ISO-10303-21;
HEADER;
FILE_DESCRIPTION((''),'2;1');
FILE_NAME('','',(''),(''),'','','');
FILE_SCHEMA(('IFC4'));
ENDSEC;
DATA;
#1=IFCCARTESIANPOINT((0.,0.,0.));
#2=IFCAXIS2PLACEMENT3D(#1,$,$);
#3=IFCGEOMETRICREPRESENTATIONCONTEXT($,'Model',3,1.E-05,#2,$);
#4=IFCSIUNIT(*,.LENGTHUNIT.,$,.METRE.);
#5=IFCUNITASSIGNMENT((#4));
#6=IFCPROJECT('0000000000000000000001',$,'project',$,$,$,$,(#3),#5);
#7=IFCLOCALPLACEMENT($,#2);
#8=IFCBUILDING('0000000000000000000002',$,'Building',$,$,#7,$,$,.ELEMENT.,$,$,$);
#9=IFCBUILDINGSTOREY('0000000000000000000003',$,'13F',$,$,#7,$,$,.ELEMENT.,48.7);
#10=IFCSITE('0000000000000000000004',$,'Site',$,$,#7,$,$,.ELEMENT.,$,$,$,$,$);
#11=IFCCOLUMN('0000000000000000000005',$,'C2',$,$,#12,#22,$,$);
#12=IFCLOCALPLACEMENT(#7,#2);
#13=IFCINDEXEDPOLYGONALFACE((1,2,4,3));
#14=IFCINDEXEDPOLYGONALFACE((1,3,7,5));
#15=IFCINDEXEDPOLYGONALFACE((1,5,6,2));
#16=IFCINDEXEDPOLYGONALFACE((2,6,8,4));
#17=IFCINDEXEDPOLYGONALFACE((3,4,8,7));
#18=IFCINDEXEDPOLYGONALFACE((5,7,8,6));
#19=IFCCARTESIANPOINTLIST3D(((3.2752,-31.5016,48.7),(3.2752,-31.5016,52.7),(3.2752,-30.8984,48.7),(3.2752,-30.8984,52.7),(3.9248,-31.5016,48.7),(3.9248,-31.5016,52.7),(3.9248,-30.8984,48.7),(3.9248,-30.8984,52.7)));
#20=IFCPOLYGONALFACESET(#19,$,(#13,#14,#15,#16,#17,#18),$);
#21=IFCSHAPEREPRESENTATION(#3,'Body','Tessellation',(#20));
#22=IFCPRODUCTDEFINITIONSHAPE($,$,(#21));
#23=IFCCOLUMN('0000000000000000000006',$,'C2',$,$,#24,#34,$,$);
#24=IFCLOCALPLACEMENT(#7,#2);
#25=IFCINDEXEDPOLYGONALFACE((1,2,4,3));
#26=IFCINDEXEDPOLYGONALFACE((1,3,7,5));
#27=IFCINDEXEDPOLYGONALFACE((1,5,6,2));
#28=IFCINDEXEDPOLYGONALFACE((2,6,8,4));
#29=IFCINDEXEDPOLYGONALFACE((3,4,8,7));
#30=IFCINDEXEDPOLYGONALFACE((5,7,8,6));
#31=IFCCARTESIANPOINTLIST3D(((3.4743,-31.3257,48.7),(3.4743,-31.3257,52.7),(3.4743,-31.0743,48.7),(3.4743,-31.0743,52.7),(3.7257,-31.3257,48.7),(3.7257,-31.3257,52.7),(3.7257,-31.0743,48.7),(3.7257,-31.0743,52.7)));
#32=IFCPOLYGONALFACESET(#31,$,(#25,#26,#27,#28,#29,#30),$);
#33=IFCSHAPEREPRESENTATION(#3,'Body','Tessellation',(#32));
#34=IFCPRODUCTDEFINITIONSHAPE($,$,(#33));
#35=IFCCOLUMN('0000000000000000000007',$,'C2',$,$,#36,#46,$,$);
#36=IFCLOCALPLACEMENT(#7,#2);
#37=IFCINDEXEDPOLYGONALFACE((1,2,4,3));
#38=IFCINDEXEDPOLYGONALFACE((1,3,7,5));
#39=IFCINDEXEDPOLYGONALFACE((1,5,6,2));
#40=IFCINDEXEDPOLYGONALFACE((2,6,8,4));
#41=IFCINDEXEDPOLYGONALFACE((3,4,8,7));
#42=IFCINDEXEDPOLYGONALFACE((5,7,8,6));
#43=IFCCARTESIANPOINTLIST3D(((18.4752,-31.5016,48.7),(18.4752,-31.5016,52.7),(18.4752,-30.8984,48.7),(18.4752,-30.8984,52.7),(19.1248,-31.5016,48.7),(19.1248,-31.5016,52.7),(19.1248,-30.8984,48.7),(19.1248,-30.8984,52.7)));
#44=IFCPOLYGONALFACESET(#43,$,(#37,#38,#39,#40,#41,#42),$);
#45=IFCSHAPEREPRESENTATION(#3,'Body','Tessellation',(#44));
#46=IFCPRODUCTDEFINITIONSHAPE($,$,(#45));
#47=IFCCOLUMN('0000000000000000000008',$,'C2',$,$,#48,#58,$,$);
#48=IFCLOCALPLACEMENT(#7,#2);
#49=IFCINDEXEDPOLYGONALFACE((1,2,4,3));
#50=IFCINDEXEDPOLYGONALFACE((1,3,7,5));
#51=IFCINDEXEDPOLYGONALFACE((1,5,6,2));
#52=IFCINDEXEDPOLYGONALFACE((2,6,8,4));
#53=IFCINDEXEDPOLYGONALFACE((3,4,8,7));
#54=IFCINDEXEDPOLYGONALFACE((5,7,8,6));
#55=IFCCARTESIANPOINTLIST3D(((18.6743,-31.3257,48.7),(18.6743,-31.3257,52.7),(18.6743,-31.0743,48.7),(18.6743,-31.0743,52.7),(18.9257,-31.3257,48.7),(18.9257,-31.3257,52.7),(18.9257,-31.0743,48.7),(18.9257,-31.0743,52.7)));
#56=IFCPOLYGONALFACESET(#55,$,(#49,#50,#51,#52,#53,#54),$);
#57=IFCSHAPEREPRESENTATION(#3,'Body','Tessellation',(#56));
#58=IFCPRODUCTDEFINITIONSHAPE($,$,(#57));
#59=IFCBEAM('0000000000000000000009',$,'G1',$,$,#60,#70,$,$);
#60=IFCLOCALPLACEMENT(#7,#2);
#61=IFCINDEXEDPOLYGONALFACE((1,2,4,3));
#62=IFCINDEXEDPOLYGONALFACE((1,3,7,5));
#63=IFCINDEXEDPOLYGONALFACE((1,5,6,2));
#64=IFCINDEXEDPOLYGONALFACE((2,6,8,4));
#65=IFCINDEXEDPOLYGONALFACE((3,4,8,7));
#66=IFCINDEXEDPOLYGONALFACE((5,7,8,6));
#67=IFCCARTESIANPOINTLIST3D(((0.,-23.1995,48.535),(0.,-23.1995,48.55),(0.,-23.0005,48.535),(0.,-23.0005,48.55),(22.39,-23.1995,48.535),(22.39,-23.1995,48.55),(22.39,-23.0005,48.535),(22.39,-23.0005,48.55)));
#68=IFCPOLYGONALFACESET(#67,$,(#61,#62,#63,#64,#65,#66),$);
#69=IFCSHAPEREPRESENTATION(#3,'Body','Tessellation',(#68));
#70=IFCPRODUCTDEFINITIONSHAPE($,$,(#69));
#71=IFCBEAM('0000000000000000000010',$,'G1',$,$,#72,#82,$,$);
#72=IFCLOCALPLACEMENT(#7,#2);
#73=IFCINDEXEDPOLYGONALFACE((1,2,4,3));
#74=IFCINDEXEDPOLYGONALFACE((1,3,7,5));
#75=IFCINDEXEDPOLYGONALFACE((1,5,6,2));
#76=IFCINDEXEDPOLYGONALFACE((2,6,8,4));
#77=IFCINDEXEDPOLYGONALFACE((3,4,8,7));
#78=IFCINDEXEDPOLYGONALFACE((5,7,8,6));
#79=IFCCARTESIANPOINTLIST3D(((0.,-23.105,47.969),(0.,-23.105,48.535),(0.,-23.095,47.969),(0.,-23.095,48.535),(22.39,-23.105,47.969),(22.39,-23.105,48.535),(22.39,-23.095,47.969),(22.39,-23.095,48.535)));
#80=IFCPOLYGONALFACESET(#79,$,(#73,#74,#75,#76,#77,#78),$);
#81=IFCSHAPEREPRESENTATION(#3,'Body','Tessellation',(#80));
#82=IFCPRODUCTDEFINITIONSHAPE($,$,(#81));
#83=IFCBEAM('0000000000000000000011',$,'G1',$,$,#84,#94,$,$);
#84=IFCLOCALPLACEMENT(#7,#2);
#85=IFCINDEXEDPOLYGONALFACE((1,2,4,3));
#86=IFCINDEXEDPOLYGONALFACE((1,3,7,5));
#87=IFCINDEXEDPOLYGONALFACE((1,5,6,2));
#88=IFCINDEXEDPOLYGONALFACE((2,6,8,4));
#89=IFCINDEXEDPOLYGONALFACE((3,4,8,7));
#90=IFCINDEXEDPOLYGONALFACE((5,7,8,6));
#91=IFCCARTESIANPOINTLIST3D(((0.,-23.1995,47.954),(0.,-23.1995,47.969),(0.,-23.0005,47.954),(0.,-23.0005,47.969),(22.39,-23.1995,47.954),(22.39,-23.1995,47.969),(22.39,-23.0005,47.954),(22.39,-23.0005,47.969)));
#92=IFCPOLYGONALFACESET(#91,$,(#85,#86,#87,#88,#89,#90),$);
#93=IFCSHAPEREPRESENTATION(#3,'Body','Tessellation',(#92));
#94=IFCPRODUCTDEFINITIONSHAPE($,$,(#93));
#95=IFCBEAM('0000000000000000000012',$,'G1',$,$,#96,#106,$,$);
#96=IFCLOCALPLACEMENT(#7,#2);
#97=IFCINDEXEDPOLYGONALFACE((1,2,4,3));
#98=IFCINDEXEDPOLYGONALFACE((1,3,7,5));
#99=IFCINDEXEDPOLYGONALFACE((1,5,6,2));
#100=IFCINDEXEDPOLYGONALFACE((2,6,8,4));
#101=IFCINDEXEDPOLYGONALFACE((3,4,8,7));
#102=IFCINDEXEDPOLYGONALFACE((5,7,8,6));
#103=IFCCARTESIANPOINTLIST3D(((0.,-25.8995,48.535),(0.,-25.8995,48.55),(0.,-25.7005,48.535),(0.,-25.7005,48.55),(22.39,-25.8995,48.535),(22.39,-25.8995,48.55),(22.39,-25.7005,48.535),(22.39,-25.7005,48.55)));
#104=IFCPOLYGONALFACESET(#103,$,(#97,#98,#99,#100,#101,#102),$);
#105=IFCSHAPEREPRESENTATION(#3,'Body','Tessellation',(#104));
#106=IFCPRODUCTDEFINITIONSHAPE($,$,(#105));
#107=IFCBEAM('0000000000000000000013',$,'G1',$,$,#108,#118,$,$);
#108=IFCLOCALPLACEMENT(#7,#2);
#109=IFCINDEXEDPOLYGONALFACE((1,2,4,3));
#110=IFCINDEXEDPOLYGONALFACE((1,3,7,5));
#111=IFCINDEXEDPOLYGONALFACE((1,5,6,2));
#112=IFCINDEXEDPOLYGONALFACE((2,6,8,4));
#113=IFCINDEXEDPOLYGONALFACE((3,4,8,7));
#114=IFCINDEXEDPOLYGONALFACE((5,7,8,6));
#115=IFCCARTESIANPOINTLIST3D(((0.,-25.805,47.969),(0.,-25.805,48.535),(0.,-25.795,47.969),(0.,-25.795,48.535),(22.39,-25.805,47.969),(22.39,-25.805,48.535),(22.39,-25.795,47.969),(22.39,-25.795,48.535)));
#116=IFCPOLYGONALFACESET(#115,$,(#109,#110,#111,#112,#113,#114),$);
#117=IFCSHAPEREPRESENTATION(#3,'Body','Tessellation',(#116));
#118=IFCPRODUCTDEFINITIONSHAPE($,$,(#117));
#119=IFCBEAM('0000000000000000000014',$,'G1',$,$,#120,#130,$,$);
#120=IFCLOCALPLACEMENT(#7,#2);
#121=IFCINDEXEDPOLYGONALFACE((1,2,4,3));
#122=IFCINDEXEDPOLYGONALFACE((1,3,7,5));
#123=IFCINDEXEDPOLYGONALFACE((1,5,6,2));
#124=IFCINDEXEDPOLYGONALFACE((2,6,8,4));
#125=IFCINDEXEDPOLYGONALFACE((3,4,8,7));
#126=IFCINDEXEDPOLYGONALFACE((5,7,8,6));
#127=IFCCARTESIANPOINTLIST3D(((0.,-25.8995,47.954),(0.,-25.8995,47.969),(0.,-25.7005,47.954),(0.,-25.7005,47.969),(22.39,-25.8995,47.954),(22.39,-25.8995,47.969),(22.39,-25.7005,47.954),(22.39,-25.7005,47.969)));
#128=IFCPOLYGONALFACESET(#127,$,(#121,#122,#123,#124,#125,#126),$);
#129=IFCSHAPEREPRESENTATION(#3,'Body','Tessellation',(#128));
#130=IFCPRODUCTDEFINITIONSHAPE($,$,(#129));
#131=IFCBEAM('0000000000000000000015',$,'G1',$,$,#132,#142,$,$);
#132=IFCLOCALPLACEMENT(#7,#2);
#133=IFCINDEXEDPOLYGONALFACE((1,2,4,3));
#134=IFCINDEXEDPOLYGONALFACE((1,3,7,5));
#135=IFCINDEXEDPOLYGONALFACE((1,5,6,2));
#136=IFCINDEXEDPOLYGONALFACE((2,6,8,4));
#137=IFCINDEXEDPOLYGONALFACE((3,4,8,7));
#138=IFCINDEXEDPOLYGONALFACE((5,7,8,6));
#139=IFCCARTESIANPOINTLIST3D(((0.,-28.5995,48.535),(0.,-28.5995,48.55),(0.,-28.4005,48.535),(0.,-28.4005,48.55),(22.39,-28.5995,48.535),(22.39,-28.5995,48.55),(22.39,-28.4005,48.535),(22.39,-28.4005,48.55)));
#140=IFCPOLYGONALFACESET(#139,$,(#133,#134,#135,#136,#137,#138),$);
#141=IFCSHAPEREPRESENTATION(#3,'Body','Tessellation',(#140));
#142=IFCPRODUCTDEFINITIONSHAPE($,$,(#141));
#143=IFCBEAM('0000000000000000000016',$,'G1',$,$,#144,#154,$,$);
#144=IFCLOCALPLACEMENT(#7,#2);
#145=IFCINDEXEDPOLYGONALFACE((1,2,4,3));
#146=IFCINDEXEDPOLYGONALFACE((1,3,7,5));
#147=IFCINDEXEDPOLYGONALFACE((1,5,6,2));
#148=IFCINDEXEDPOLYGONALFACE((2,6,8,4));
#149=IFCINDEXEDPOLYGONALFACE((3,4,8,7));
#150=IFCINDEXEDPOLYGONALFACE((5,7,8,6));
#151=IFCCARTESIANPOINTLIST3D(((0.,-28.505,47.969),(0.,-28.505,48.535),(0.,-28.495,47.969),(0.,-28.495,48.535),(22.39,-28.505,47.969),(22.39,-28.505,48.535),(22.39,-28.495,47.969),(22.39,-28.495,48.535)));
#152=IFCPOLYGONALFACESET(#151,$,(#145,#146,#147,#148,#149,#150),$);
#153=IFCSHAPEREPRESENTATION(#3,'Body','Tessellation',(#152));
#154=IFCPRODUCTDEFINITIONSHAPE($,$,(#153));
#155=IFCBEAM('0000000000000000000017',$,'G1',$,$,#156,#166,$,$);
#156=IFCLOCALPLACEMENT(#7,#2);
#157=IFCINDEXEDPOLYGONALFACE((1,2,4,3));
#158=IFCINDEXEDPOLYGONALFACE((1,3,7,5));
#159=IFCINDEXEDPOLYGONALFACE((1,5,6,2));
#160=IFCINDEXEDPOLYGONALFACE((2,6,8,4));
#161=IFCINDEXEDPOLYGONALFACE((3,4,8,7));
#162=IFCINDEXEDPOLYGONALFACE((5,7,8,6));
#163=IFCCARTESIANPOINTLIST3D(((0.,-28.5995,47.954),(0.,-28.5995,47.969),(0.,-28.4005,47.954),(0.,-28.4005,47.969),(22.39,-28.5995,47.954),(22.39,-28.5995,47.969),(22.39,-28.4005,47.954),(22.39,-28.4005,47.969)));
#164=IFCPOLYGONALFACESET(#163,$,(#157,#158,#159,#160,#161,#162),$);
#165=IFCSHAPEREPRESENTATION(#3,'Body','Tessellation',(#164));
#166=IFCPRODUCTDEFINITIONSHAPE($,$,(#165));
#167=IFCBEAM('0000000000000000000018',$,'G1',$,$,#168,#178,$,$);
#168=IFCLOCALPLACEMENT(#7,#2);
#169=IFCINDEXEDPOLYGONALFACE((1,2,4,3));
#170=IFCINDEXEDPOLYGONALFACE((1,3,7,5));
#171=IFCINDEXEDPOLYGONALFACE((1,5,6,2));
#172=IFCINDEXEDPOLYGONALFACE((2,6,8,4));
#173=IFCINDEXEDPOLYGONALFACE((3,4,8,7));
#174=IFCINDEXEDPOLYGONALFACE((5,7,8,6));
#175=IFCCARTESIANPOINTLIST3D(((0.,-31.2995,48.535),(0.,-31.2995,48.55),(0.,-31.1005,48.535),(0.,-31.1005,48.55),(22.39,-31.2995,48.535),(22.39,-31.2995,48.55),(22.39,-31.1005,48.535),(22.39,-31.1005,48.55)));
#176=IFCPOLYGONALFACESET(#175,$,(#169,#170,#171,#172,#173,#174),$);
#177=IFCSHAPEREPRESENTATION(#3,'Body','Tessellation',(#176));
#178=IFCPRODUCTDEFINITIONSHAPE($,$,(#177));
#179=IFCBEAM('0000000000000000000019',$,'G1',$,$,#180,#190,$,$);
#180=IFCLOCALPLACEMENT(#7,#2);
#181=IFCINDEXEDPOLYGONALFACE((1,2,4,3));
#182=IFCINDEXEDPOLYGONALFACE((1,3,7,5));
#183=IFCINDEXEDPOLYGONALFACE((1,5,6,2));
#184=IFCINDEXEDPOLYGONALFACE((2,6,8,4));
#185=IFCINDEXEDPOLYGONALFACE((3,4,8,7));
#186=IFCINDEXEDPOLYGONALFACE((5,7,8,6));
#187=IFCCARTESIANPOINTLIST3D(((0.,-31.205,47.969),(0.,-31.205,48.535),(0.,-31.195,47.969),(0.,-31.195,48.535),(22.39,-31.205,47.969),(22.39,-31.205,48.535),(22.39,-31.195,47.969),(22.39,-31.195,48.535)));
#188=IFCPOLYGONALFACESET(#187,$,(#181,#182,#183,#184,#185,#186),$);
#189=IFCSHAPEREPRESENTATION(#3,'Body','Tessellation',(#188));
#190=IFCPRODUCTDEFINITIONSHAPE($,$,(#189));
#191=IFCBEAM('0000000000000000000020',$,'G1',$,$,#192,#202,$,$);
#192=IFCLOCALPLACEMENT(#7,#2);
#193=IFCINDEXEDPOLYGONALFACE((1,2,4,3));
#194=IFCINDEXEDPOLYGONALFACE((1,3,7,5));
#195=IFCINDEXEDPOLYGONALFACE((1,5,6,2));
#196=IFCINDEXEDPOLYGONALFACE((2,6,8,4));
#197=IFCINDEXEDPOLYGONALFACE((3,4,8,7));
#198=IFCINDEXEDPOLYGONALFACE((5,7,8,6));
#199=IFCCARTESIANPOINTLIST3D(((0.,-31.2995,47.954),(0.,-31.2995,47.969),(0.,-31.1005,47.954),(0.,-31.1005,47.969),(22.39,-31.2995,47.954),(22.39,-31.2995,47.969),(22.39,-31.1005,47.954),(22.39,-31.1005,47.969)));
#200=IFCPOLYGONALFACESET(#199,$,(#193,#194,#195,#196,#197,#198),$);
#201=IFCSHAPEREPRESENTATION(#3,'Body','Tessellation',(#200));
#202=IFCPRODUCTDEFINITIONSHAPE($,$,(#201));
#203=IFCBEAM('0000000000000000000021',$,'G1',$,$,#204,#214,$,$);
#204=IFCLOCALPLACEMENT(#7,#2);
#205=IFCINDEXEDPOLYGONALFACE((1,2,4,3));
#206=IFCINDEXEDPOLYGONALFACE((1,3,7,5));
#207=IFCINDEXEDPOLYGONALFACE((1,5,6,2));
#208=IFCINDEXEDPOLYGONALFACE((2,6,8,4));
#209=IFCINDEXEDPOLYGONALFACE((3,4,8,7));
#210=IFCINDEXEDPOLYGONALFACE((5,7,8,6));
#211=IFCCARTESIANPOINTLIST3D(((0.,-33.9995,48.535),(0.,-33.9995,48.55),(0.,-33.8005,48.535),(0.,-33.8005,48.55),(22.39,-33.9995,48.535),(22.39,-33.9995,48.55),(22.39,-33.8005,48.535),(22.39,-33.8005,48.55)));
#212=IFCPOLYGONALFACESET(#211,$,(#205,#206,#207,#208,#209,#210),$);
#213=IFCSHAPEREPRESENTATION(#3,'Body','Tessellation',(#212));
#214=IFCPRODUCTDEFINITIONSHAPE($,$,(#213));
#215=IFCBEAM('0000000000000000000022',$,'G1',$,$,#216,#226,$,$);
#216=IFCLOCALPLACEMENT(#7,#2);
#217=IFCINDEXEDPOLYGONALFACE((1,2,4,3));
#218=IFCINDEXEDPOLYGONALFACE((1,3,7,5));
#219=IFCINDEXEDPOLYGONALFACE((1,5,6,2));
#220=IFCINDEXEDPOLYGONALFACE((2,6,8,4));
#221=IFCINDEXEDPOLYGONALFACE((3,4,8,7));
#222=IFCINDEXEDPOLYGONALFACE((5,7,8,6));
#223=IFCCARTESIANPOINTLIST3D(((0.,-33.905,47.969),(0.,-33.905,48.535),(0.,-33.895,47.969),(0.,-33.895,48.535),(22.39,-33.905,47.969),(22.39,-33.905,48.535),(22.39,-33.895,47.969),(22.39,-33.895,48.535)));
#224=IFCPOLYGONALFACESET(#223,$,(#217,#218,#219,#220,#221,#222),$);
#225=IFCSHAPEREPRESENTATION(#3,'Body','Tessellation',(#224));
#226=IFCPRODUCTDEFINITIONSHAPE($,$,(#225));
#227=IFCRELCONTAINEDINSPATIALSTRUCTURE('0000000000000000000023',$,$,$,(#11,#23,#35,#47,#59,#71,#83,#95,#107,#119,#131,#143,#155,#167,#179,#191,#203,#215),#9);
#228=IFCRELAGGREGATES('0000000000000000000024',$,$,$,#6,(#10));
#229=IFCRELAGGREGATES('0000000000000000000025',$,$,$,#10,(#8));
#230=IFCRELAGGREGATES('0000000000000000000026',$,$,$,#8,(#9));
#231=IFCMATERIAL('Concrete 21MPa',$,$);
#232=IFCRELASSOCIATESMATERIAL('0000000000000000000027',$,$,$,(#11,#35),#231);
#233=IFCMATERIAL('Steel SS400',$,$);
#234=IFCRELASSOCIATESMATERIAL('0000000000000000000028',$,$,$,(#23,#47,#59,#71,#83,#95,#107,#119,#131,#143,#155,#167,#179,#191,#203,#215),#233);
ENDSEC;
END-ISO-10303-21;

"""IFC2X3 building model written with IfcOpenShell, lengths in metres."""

from ifc_helpers import new_model, si_unit, frame, origin, origin_2d, place, context, project, spatial, rectangle, extrude, material, element, save


model = new_model("IFC2X3")

# Units and contexts
model_context = context("Model", 3, precision=1e-05, world=origin())
ifc_project = project(units=[si_unit("LENGTHUNIT", "METRE")], contexts=[model_context])

# Site, building, storey
placement = place(None, origin())
site = spatial("IfcSite", under=ifc_project, at=placement, Name="Site", CompositionType="ELEMENT")
building = spatial("IfcBuilding", under=site, at=placement, Name="Building", CompositionType="ELEMENT")
storey = spatial("IfcBuildingStorey", under=building, at=placement, Name="13F", CompositionType="ELEMENT", Elevation=48.7)

# Columns
ifc_material_1 = material(Name="Concrete 21MPa")
column_1_placement = place(None, frame((3.6, -31.2, 48.7)))
element("IfcColumn", 1, at=column_1_placement, inside=storey, material=ifc_material_1, Name="C2", context=model_context, shape_type="SweptSolid", body=[
    extrude(rectangle(XDim=0.6496, YDim=0.6032, at=origin_2d()), origin(), (0.0, 0.0, 1.0), 4.0),
])
ifc_material_2 = material(Name="Steel SS400")
column_2_placement = place(None, frame((3.6, -31.2, 48.7)))
element("IfcColumn", 2, at=column_2_placement, inside=storey, material=ifc_material_2, Name="C2", context=model_context, shape_type="SweptSolid", body=[
    extrude(rectangle(XDim=0.2513, YDim=0.2513, at=origin_2d()), origin(), (0.0, 0.0, 1.0), 4.0),
])
column_3_placement = place(None, frame((18.8, -31.2, 48.7)))
element("IfcColumn", 3, at=column_3_placement, inside=storey, material=ifc_material_1, Name="C2", context=model_context, shape_type="SweptSolid", body=[
    extrude(rectangle(XDim=0.6496, YDim=0.6032, at=origin_2d()), origin(), (0.0, 0.0, 1.0), 4.0),
])
column_4_placement = place(None, frame((18.8, -31.2, 48.7)))
element("IfcColumn", 4, at=column_4_placement, inside=storey, material=ifc_material_2, Name="C2", context=model_context, shape_type="SweptSolid", body=[
    extrude(rectangle(XDim=0.2513, YDim=0.2513, at=origin_2d()), origin(), (0.0, 0.0, 1.0), 4.0),
])

# Beams
beam_1_placement = place(None, frame((11.195, -23.1, 48.535)))
element("IfcBeam", 5, at=beam_1_placement, inside=storey, material=ifc_material_2, Name="G1", context=model_context, shape_type="SweptSolid", body=[
    extrude(rectangle(XDim=22.39, YDim=0.199, at=origin_2d()), origin(), (0.0, 0.0, 1.0), 0.015),
])
beam_2_placement = place(None, frame((11.195, -23.1, 47.969)))
element("IfcBeam", 6, at=beam_2_placement, inside=storey, material=ifc_material_2, Name="G1", context=model_context, shape_type="SweptSolid", body=[
    extrude(rectangle(XDim=22.39, YDim=0.01, at=origin_2d()), origin(), (0.0, 0.0, 1.0), 0.566),
])
for number, where, name in (
    (7, (11.195, -23.1, 47.954), "G1"),
    (8, (11.195, -25.8, 48.535), "G1"),
):
    element("IfcBeam", number, at=place(None, frame(where)), inside=storey, material=ifc_material_2, Name=name, context=model_context, shape_type="SweptSolid", body=[
        extrude(rectangle(XDim=22.39, YDim=0.199, at=origin_2d()), origin(), (0.0, 0.0, 1.0), 0.015),
    ])
beam_3_placement = place(None, frame((11.195, -25.8, 47.969)))
element("IfcBeam", 9, at=beam_3_placement, inside=storey, material=ifc_material_2, Name="G1", context=model_context, shape_type="SweptSolid", body=[
    extrude(rectangle(XDim=22.39, YDim=0.01, at=origin_2d()), origin(), (0.0, 0.0, 1.0), 0.566),
])
for number, where, name in (
    (10, (11.195, -25.8, 47.954), "G1"),
    (11, (11.195, -28.5, 48.535), "G1"),
):
    element("IfcBeam", number, at=place(None, frame(where)), inside=storey, material=ifc_material_2, Name=name, context=model_context, shape_type="SweptSolid", body=[
        extrude(rectangle(XDim=22.39, YDim=0.199, at=origin_2d()), origin(), (0.0, 0.0, 1.0), 0.015),
    ])
beam_4_placement = place(None, frame((11.195, -28.5, 47.969)))
element("IfcBeam", 12, at=beam_4_placement, inside=storey, material=ifc_material_2, Name="G1", context=model_context, shape_type="SweptSolid", body=[
    extrude(rectangle(XDim=22.39, YDim=0.01, at=origin_2d()), origin(), (0.0, 0.0, 1.0), 0.566),
])
for number, where, name in (
    (13, (11.195, -28.5, 47.954), "G1"),
    (14, (11.195, -31.2, 48.535), "G1"),
):
    element("IfcBeam", number, at=place(None, frame(where)), inside=storey, material=ifc_material_2, Name=name, context=model_context, shape_type="SweptSolid", body=[
        extrude(rectangle(XDim=22.39, YDim=0.199, at=origin_2d()), origin(), (0.0, 0.0, 1.0), 0.015),
    ])
beam_5_placement = place(None, frame((11.195, -31.2, 47.969)))
element("IfcBeam", 15, at=beam_5_placement, inside=storey, material=ifc_material_2, Name="G1", context=model_context, shape_type="SweptSolid", body=[
    extrude(rectangle(XDim=22.39, YDim=0.01, at=origin_2d()), origin(), (0.0, 0.0, 1.0), 0.566),
])
for number, where, name in (
    (16, (11.195, -31.2, 47.954), "G1"),
    (17, (11.195, -33.9, 48.535), "G1"),
):
    element("IfcBeam", number, at=place(None, frame(where)), inside=storey, material=ifc_material_2, Name=name, context=model_context, shape_type="SweptSolid", body=[
        extrude(rectangle(XDim=22.39, YDim=0.199, at=origin_2d()), origin(), (0.0, 0.0, 1.0), 0.015),
    ])
beam_6_placement = place(None, frame((11.195, -33.9, 47.969)))
element("IfcBeam", 18, at=beam_6_placement, inside=storey, material=ifc_material_2, Name="G1", context=model_context, shape_type="SweptSolid", body=[
    extrude(rectangle(XDim=22.39, YDim=0.01, at=origin_2d()), origin(), (0.0, 0.0, 1.0), 0.566),
])

save(model, "model.ifc")
